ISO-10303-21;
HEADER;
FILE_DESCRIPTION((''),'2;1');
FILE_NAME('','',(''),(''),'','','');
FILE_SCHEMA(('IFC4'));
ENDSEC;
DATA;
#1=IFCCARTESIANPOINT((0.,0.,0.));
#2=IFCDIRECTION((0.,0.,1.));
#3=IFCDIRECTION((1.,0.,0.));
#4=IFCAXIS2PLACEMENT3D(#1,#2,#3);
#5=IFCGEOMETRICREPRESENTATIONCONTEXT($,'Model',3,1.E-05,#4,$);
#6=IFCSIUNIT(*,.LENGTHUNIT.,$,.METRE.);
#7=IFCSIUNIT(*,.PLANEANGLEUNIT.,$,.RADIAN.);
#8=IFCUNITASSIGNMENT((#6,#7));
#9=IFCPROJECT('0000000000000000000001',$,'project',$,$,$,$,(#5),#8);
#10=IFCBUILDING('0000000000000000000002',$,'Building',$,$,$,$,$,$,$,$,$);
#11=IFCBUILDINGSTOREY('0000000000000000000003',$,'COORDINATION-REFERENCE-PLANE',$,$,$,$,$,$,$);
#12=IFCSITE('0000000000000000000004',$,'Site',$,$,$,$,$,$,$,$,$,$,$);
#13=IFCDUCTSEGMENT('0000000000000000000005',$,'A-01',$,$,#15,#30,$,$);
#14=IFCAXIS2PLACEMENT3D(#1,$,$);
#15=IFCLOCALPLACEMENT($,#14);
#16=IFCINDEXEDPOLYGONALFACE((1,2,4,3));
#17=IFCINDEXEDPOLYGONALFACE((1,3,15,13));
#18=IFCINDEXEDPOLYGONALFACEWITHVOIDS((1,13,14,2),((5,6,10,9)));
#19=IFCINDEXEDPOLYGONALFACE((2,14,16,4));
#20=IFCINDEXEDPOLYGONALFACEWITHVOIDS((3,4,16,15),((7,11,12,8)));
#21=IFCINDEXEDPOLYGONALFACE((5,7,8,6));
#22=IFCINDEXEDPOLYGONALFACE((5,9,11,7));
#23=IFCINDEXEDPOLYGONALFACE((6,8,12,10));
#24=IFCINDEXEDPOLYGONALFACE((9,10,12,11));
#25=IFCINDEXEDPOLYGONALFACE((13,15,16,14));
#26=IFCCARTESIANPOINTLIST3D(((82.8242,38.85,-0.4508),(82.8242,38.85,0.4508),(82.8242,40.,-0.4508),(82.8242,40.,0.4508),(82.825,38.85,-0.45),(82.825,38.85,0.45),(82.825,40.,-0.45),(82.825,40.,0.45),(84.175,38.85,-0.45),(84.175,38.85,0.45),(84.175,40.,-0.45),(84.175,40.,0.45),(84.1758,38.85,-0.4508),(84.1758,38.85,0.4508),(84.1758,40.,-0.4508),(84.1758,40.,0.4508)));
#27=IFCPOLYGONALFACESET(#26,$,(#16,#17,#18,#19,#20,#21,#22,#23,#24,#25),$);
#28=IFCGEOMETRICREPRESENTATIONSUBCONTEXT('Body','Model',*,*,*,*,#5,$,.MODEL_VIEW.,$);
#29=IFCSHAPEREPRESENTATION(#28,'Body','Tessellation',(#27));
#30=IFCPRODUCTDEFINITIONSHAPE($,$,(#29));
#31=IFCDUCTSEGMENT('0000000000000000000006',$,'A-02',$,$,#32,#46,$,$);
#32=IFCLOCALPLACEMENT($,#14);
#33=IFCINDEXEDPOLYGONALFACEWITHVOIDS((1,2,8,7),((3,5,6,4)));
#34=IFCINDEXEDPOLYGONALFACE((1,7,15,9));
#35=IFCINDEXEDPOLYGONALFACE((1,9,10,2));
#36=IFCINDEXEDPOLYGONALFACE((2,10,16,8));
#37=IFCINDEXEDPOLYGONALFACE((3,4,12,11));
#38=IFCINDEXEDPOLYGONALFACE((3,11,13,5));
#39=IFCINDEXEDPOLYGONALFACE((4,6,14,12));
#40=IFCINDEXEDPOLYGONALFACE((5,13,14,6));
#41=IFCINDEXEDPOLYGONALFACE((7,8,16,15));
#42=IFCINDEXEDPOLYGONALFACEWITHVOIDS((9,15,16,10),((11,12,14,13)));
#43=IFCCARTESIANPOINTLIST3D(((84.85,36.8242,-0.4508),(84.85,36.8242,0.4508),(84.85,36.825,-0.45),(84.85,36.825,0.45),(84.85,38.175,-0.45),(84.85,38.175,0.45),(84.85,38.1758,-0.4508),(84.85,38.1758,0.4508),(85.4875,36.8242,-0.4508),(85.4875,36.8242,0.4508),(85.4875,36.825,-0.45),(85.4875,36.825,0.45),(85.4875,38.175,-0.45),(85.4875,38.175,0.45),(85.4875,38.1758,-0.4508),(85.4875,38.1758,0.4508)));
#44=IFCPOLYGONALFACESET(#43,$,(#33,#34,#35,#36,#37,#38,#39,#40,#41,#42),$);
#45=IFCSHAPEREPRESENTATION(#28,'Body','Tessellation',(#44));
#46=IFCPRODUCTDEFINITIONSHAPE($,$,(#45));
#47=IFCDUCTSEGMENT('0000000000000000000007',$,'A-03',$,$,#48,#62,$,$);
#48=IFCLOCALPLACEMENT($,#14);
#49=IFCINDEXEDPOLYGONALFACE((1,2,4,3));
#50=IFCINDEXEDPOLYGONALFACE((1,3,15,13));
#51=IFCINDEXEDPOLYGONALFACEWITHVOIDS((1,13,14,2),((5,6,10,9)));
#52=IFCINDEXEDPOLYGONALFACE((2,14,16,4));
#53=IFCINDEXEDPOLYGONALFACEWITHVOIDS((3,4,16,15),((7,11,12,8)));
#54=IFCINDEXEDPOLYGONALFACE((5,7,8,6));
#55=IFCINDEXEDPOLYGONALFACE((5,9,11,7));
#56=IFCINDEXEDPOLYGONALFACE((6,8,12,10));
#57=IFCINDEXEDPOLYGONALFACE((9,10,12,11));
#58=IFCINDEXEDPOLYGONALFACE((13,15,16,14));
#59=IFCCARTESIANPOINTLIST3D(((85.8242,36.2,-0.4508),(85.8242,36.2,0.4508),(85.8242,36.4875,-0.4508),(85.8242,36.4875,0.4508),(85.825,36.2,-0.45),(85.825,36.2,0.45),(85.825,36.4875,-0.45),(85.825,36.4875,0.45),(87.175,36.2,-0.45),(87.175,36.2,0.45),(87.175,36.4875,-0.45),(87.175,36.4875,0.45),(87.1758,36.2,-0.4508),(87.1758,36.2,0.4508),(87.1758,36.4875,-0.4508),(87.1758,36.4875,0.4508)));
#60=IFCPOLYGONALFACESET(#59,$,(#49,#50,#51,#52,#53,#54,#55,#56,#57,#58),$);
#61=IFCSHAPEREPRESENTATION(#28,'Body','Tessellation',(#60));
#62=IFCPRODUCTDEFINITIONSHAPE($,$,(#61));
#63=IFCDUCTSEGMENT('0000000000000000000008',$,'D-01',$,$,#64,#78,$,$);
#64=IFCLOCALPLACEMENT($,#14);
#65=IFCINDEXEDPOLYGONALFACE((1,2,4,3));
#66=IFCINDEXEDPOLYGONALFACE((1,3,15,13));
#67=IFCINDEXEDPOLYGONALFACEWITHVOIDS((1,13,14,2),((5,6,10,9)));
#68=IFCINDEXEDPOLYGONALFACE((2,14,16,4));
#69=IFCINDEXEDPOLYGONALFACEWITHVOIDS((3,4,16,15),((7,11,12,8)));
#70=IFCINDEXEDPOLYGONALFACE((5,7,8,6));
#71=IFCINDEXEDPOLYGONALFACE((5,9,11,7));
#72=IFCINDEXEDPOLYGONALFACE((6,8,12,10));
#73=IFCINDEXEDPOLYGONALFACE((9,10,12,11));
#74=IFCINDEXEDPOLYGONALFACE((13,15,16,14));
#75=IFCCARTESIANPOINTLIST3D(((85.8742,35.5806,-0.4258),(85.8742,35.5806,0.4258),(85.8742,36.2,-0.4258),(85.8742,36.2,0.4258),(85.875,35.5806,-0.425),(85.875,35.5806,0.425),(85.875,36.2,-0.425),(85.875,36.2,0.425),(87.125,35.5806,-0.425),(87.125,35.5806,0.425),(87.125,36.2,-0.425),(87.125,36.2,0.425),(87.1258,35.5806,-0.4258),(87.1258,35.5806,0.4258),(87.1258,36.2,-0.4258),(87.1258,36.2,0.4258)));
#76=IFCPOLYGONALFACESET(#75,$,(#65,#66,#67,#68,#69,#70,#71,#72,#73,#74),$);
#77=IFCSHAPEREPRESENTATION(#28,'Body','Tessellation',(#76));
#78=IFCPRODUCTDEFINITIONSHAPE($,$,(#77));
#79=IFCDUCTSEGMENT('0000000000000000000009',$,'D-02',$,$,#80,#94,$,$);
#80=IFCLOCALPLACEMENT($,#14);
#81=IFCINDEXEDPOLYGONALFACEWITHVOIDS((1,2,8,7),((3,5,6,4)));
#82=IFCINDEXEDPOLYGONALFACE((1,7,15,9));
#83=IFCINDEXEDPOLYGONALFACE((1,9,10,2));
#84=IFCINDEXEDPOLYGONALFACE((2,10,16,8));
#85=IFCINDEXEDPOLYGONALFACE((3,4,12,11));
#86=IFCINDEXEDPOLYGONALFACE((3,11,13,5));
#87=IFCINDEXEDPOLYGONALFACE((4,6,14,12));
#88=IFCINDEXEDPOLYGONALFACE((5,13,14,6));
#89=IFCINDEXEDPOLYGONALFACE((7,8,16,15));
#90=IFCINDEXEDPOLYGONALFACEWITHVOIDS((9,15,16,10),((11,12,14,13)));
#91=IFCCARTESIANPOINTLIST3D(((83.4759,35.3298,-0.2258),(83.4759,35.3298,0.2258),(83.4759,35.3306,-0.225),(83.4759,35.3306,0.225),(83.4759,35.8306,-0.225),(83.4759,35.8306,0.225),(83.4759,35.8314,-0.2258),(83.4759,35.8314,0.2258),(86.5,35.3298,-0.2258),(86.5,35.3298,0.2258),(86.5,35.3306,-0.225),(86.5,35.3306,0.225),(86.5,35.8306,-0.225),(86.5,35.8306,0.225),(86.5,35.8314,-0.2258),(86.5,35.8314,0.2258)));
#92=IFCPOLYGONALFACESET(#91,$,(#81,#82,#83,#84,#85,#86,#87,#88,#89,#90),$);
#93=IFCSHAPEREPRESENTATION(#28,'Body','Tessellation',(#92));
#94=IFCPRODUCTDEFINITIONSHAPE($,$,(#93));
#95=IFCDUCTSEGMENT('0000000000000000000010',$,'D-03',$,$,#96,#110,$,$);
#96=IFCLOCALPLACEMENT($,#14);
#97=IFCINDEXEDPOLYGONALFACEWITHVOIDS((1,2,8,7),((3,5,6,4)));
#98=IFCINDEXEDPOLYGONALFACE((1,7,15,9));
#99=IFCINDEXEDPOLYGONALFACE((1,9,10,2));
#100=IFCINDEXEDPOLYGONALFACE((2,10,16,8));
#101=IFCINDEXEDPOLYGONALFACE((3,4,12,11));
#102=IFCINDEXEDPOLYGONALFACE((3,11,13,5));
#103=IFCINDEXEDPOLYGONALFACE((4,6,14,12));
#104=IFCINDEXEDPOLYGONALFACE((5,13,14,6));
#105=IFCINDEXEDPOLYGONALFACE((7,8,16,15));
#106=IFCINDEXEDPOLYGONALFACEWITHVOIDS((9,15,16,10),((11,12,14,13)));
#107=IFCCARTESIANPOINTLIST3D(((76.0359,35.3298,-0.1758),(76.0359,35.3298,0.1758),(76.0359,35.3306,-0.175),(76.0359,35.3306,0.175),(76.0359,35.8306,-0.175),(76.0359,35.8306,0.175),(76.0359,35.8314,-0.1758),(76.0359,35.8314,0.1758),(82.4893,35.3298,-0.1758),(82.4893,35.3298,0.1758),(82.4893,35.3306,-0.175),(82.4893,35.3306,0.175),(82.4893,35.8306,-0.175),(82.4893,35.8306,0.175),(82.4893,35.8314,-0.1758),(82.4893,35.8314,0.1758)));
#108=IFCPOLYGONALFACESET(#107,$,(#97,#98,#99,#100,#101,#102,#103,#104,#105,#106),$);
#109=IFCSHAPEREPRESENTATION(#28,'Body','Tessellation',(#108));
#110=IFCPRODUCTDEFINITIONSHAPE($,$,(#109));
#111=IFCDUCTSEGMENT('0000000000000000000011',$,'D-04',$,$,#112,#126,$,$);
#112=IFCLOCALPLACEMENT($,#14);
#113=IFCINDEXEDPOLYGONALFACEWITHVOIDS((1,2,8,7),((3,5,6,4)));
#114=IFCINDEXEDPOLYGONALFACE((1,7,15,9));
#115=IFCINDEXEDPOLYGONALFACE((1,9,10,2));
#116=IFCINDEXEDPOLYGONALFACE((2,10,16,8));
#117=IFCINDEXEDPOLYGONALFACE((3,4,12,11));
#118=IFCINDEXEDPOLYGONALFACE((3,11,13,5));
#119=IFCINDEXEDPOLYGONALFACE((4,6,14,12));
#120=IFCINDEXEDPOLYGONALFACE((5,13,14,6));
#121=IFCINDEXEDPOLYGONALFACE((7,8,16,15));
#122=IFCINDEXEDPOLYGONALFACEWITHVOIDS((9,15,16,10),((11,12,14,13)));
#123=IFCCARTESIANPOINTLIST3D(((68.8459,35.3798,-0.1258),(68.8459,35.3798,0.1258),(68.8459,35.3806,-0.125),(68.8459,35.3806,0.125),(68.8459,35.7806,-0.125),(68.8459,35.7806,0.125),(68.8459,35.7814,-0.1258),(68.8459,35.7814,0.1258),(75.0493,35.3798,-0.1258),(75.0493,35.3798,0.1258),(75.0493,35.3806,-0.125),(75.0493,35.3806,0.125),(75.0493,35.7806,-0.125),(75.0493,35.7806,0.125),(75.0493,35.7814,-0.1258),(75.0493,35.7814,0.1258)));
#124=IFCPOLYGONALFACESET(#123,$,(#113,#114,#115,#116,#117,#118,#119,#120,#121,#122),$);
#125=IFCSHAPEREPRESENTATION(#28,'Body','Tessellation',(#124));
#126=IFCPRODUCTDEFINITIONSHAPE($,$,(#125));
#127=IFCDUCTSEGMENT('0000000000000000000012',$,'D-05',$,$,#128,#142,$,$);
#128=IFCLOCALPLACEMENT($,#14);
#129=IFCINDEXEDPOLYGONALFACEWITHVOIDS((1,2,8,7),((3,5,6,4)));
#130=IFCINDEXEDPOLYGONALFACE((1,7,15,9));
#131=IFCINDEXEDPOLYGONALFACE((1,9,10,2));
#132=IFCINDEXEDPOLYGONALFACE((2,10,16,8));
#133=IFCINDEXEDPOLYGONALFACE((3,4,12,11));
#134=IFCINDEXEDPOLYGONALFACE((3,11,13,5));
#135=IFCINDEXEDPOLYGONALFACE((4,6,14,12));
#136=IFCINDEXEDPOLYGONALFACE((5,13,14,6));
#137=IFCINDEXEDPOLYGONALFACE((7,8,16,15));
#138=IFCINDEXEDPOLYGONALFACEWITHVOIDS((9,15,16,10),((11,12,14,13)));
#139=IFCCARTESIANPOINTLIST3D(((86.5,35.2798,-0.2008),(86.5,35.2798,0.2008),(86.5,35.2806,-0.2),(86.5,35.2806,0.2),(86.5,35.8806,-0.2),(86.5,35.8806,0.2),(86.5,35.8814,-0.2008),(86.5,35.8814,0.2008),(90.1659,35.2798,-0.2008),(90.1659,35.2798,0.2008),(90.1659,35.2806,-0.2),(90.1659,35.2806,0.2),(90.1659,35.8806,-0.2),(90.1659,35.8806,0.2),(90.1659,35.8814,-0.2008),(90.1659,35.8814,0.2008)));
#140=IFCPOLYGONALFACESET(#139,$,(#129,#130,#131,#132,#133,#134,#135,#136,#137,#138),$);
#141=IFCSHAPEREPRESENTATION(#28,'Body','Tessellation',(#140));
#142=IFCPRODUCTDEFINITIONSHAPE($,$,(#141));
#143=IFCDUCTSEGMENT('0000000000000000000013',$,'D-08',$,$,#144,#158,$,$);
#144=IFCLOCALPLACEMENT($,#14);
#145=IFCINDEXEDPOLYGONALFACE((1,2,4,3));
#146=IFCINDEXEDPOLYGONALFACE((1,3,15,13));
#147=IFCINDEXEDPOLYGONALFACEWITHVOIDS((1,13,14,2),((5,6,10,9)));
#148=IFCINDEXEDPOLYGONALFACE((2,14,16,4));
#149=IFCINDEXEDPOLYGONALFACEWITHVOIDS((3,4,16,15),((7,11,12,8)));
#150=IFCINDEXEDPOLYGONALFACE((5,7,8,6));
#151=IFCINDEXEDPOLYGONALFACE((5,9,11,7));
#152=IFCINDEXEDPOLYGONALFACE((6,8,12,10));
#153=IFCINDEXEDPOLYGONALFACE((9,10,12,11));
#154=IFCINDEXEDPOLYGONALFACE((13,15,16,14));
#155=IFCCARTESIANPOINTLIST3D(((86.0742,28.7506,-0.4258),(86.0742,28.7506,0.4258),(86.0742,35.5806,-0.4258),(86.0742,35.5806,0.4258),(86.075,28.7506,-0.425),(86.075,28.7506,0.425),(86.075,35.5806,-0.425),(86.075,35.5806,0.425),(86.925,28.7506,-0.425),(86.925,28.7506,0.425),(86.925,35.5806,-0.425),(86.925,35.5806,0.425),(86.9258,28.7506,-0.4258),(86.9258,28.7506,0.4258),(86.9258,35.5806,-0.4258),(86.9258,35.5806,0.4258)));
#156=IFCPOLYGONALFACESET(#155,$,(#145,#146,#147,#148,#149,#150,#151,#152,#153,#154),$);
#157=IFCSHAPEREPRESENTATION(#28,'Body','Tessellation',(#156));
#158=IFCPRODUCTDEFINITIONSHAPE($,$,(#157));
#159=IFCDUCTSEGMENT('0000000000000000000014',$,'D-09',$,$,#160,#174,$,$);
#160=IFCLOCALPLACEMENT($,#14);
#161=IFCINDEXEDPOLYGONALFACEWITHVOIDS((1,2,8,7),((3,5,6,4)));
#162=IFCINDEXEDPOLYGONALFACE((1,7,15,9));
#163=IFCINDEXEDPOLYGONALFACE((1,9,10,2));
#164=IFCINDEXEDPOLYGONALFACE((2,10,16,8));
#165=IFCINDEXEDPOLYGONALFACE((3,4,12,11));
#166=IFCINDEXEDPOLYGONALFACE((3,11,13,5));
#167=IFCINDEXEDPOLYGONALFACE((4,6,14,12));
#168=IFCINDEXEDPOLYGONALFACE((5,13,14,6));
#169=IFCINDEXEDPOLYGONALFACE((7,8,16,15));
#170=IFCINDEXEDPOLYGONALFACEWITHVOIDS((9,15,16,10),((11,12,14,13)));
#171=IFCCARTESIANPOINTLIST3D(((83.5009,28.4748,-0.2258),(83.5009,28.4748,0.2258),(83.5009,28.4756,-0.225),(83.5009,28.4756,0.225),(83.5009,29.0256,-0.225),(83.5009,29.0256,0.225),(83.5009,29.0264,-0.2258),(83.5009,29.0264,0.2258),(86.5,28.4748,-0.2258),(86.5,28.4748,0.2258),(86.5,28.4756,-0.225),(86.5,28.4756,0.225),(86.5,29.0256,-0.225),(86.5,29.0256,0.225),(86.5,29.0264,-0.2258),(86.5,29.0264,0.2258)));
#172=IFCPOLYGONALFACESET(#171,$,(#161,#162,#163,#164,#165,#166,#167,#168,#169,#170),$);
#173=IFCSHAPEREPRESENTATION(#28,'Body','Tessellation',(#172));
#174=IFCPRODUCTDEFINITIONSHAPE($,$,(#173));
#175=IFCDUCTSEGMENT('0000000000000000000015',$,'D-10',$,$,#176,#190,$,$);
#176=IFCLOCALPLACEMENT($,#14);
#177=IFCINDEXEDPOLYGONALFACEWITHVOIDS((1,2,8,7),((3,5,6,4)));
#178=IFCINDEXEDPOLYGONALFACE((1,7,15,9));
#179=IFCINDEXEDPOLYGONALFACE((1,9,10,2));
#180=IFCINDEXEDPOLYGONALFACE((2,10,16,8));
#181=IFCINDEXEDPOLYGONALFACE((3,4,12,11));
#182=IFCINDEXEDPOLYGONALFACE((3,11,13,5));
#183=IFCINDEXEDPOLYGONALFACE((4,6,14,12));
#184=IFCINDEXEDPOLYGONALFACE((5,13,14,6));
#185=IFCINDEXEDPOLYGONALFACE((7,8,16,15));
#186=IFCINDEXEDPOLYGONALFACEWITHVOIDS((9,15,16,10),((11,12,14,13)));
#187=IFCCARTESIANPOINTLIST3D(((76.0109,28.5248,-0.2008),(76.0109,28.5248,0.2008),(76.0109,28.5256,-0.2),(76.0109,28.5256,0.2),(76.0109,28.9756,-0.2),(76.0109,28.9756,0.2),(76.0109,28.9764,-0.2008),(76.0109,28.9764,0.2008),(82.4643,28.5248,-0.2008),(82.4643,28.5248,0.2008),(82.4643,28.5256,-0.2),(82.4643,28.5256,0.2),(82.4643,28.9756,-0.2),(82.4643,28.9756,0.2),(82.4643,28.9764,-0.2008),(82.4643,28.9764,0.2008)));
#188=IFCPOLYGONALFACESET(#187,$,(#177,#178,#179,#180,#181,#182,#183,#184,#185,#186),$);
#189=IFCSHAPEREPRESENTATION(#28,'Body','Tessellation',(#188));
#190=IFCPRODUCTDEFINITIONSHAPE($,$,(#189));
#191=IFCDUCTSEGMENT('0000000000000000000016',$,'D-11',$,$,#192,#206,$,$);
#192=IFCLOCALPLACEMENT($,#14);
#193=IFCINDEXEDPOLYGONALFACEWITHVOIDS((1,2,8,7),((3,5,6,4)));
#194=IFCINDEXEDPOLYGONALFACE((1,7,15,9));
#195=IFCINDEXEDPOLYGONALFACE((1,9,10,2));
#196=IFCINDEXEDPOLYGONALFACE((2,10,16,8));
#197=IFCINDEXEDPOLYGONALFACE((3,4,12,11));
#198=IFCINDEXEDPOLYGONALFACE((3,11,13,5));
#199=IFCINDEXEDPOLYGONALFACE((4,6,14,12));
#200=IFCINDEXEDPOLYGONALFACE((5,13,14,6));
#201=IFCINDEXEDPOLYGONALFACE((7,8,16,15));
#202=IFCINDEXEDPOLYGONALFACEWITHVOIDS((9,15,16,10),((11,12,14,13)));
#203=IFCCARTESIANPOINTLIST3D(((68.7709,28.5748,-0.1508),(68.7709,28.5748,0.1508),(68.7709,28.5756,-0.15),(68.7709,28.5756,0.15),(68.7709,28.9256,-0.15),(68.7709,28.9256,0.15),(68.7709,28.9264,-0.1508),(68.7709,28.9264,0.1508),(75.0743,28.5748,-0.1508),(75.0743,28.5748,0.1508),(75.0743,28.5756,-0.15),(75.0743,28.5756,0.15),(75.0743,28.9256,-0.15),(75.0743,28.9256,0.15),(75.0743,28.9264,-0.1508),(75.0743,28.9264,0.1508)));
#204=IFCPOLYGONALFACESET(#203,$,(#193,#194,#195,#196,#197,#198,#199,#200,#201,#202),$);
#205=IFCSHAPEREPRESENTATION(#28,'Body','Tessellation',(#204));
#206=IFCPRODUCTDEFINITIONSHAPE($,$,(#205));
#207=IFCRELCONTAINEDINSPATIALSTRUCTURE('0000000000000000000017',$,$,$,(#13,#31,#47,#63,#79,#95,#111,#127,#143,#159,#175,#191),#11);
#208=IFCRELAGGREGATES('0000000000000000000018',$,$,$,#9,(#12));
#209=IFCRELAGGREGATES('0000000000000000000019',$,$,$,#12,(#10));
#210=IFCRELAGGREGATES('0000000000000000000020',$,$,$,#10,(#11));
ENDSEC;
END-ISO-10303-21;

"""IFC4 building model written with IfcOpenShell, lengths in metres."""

from ifc_helpers import new_model, si_unit, frame, origin, origin_with_axes, place, context, subcontext, project, spatial, hollow_rectangle, extrude, element, save


model = new_model("IFC4")

# Units and contexts
model_context = context("Model", 3, precision=1e-05, world=origin_with_axes())
body_context = subcontext(model_context, "Body", "Model", "MODEL_VIEW")
ifc_project = project(units=[si_unit("LENGTHUNIT", "METRE"), si_unit("PLANEANGLEUNIT", "RADIAN")], contexts=[model_context])

# Site, building, storey
site = spatial("IfcSite", under=ifc_project, Name="Site")
building = spatial("IfcBuilding", under=site, Name="Building")
storey = spatial("IfcBuildingStorey", under=building, Name="COORDINATION-REFERENCE-PLANE")

# Duct segments
duct_segment_1_placement = place(None, frame((83.5, 38.85, 0.0), z_axis=(0.0, 1.0, 0.0), x_axis=(1.0, 0.0, 0.0)))
element("IfcDuctSegment", 1, at=duct_segment_1_placement, inside=storey, Name="A-01", context=body_context, shape_type="SweptSolid", body=[
    extrude(hollow_rectangle(XDim=1.3516, YDim=0.9016, WallThickness=0.0008), origin(), (0.0, 0.0, 1.0), 1.15),
])
duct_segment_2_placement = place(None, frame((84.85, 37.5, 0.0), z_axis=(1.0, 0.0, 0.0), x_axis=(0.0, 1.0, 0.0)))
element("IfcDuctSegment", 2, at=duct_segment_2_placement, inside=storey, Name="A-02", context=body_context, shape_type="SweptSolid", body=[
    extrude(hollow_rectangle(XDim=1.3516, YDim=0.9016, WallThickness=0.0008), origin(), (0.0, 0.0, 1.0), 0.6375),
])
duct_segment_3_placement = place(None, frame((86.5, 36.2, 0.0), z_axis=(0.0, 1.0, 0.0), x_axis=(1.0, 0.0, 0.0)))
element("IfcDuctSegment", 3, at=duct_segment_3_placement, inside=storey, Name="A-03", context=body_context, shape_type="SweptSolid", body=[
    extrude(hollow_rectangle(XDim=1.3516, YDim=0.9016, WallThickness=0.0008), origin(), (0.0, 0.0, 1.0), 0.2875),
])
duct_segment_4_placement = place(None, frame((86.5, 35.5806, 0.0), z_axis=(0.0, 1.0, 0.0), x_axis=(1.0, 0.0, 0.0)))
element("IfcDuctSegment", 4, at=duct_segment_4_placement, inside=storey, Name="D-01", context=body_context, shape_type="SweptSolid", body=[
    extrude(hollow_rectangle(XDim=1.2516, YDim=0.8516, WallThickness=0.0008), origin(), (0.0, 0.0, 1.0), 0.6194),
])
duct_segment_5_placement = place(None, frame((83.4759, 35.5806, 0.0), z_axis=(1.0, 0.0, 0.0), x_axis=(0.0, 1.0, 0.0)))
element("IfcDuctSegment", 5, at=duct_segment_5_placement, inside=storey, Name="D-02", context=body_context, shape_type="SweptSolid", body=[
    extrude(hollow_rectangle(XDim=0.5016, YDim=0.4516, WallThickness=0.0008), origin(), (0.0, 0.0, 1.0), 3.0241),
])
duct_segment_6_placement = place(None, frame((76.0359, 35.5806, 0.0), z_axis=(1.0, 0.0, 0.0), x_axis=(0.0, 1.0, 0.0)))
element("IfcDuctSegment", 6, at=duct_segment_6_placement, inside=storey, Name="D-03", context=body_context, shape_type="SweptSolid", body=[
    extrude(hollow_rectangle(XDim=0.5016, YDim=0.3516, WallThickness=0.0008), origin(), (0.0, 0.0, 1.0), 6.4534),
])
duct_segment_7_placement = place(None, frame((68.8459, 35.5806, 0.0), z_axis=(1.0, 0.0, 0.0), x_axis=(0.0, 1.0, 0.0)))
element("IfcDuctSegment", 7, at=duct_segment_7_placement, inside=storey, Name="D-04", context=body_context, shape_type="SweptSolid", body=[
    extrude(hollow_rectangle(XDim=0.4016, YDim=0.2516, WallThickness=0.0008), origin(), (0.0, 0.0, 1.0), 6.2034),
])
duct_segment_8_placement = place(None, frame((86.5, 35.5806, 0.0), z_axis=(1.0, 0.0, 0.0), x_axis=(0.0, 1.0, 0.0)))
element("IfcDuctSegment", 8, at=duct_segment_8_placement, inside=storey, Name="D-05", context=body_context, shape_type="SweptSolid", body=[
    extrude(hollow_rectangle(XDim=0.6016, YDim=0.4016, WallThickness=0.0008), origin(), (0.0, 0.0, 1.0), 3.6659),
])
duct_segment_9_placement = place(None, frame((86.5, 28.7506, 0.0), z_axis=(0.0, 1.0, 0.0), x_axis=(1.0, 0.0, 0.0)))
element("IfcDuctSegment", 9, at=duct_segment_9_placement, inside=storey, Name="D-08", context=body_context, shape_type="SweptSolid", body=[
    extrude(hollow_rectangle(XDim=0.8516, YDim=0.8516, WallThickness=0.0008), origin(), (0.0, 0.0, 1.0), 6.83),
])
duct_segment_10_placement = place(None, frame((83.5009, 28.7506, 0.0), z_axis=(1.0, 0.0, 0.0), x_axis=(0.0, 1.0, 0.0)))
element("IfcDuctSegment", 10, at=duct_segment_10_placement, inside=storey, Name="D-09", context=body_context, shape_type="SweptSolid", body=[
    extrude(hollow_rectangle(XDim=0.5516, YDim=0.4516, WallThickness=0.0008), origin(), (0.0, 0.0, 1.0), 2.9991),
])
duct_segment_11_placement = place(None, frame((76.0109, 28.7506, 0.0), z_axis=(1.0, 0.0, 0.0), x_axis=(0.0, 1.0, 0.0)))
element("IfcDuctSegment", 11, at=duct_segment_11_placement, inside=storey, Name="D-10", context=body_context, shape_type="SweptSolid", body=[
    extrude(hollow_rectangle(XDim=0.4516, YDim=0.4016, WallThickness=0.0008), origin(), (0.0, 0.0, 1.0), 6.4534),
])
duct_segment_12_placement = place(None, frame((68.7709, 28.7506, 0.0), z_axis=(1.0, 0.0, 0.0), x_axis=(0.0, 1.0, 0.0)))
element("IfcDuctSegment", 12, at=duct_segment_12_placement, inside=storey, Name="D-11", context=body_context, shape_type="SweptSolid", body=[
    extrude(hollow_rectangle(XDim=0.3516, YDim=0.3016, WallThickness=0.0008), origin(), (0.0, 0.0, 1.0), 6.3034),
])

save(model, "model.ifc")
